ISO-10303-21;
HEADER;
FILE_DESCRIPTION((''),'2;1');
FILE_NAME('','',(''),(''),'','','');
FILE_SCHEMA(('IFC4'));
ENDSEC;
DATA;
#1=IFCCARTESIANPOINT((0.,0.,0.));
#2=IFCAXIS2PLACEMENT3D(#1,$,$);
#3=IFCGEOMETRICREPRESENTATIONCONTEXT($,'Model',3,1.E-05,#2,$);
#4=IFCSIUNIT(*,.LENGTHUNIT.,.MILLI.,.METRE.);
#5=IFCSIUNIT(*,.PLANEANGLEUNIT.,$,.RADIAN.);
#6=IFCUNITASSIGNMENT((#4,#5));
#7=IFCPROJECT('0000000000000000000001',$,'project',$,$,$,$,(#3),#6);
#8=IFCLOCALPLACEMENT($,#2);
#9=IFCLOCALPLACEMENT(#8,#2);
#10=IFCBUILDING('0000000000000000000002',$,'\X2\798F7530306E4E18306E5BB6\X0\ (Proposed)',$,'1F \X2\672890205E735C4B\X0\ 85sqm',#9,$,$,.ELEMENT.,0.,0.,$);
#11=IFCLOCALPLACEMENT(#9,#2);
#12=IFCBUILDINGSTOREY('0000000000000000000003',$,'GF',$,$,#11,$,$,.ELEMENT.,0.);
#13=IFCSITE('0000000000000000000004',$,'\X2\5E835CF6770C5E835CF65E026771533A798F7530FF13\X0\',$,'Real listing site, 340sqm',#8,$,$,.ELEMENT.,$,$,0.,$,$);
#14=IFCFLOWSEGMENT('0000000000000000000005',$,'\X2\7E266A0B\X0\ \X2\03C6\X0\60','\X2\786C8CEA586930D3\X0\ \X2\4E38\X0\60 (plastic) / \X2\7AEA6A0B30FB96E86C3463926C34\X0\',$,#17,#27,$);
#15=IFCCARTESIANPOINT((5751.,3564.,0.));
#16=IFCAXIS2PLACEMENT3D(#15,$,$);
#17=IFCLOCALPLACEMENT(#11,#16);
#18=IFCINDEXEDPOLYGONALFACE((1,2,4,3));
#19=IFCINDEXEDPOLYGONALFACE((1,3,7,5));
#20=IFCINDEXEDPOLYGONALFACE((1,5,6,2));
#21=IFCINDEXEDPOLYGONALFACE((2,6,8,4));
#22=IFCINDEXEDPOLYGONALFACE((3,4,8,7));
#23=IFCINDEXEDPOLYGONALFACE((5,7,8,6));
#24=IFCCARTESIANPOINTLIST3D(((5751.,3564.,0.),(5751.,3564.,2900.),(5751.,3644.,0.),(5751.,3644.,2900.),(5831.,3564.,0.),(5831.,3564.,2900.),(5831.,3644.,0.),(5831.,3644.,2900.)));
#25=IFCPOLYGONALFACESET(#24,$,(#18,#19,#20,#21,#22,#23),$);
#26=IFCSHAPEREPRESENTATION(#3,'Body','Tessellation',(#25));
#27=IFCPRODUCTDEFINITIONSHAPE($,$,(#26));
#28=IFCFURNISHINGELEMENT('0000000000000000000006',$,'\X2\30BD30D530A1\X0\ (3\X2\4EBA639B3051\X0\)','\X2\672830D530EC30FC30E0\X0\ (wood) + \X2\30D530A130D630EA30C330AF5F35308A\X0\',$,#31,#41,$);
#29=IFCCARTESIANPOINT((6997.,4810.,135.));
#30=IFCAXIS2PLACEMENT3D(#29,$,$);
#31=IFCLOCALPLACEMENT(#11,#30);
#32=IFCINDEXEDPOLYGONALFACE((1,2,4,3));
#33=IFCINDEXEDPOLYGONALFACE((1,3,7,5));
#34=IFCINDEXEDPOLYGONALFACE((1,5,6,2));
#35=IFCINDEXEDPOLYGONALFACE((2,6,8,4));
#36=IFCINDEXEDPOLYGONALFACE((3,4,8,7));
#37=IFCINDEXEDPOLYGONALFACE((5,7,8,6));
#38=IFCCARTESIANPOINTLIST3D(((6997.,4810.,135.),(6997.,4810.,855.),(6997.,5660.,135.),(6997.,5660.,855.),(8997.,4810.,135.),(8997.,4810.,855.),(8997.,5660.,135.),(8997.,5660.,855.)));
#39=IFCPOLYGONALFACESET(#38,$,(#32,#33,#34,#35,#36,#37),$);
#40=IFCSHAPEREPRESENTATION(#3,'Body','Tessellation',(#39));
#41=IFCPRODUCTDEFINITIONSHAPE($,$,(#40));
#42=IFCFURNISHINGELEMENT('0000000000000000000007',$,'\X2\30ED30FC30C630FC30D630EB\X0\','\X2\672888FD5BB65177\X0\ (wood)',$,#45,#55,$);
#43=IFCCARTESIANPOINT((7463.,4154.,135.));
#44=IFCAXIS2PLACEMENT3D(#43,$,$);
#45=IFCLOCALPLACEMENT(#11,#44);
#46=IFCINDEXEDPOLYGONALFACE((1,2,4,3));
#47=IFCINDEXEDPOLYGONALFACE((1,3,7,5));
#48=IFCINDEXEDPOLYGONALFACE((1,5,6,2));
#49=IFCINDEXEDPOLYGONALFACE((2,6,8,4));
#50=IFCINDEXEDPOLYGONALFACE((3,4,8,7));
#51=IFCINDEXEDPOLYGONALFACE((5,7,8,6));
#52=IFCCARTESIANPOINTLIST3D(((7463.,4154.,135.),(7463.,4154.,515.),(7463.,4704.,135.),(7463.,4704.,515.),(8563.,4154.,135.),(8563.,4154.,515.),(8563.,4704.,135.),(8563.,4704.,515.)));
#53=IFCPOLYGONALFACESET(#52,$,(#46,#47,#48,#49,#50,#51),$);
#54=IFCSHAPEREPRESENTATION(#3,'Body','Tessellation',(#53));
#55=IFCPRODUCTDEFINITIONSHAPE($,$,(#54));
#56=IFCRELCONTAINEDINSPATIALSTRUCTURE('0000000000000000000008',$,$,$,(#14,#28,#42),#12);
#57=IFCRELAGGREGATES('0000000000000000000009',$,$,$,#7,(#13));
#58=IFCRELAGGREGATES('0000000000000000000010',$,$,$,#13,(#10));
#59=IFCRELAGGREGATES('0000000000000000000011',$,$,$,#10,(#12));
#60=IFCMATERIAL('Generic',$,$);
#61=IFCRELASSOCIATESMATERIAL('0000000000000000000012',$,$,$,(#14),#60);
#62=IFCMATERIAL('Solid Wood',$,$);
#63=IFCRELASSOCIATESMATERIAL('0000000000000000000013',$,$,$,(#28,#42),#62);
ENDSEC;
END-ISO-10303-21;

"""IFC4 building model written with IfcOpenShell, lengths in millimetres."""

from ifc_helpers import new_model, si_unit, frame, frame_2d, origin, place, context, project, spatial, rectangle, extrude, material, element, save


model = new_model("IFC4")

# Units and contexts
model_context = context("Model", 3, precision=1e-05, world=origin())
ifc_project = project(units=[si_unit("LENGTHUNIT", "METRE", prefix="MILLI"), si_unit("PLANEANGLEUNIT", "RADIAN")], contexts=[model_context])

# Site, building, storey
site_placement = place(None, origin())
site = spatial("IfcSite", under=ifc_project, at=site_placement, Name="広島県広島市東区福田３", ObjectType="Real listing site, 340sqm", CompositionType="ELEMENT", RefElevation=0.0)
building_placement = place(site_placement, origin())
building = spatial("IfcBuilding", under=site, at=building_placement, Name="福田の丘の家 (Proposed)", ObjectType="1F 木造平屋 85sqm", CompositionType="ELEMENT", ElevationOfRefHeight=0.0, ElevationOfTerrain=0.0)
storey_placement = place(building_placement, origin())
storey = spatial("IfcBuildingStorey", under=building, at=storey_placement, Name="GF", CompositionType="ELEMENT", Elevation=0.0)

# Shared definitions
ifc_material_1 = material(Name="Solid Wood")

# Shared definitions
ifc_material_2 = material(Name="Generic")

# Flow segment
flow_segment_1_placement = place(storey_placement, frame((5751.0, 3564.0, 0.0)))
element("IfcFlowSegment", 1, at=flow_segment_1_placement, inside=storey, material=ifc_material_2, Name="縦樋 φ60", Description="硬質塩ビ 丸60 (plastic) / 竪樋・雨水排水", context=model_context, shape_type="SweptSolid", body=[
    extrude(rectangle(XDim=80.0, YDim=80.0, at=frame_2d((40.0, 40.0))), frame((5751.0, 3564.0, 0.0)), (0.0, 0.0, 1.0), 2900.0),
])

# Furnishing elements
furnishing_1_placement = place(storey_placement, frame((6997.0, 4810.0, 135.0)))
element("IfcFurnishingElement", 2, at=furnishing_1_placement, inside=storey, material=ifc_material_1, Name="ソファ (3人掛け)", Description="木フレーム (wood) + ファブリック張り", context=model_context, shape_type="SweptSolid", body=[
    extrude(rectangle(XDim=2000.0, YDim=850.0, at=frame_2d((1000.0, 425.0))), frame((6997.0, 4810.0, 135.0)), (0.0, 0.0, 1.0), 720.0),
])
furnishing_2_placement = place(storey_placement, frame((7463.0, 4154.0, 135.0)))
element("IfcFurnishingElement", 3, at=furnishing_2_placement, inside=storey, material=ifc_material_1, Name="ローテーブル", Description="木製家具 (wood)", context=model_context, shape_type="SweptSolid", body=[
    extrude(rectangle(XDim=1100.0, YDim=550.0, at=frame_2d((550.0, 275.0))), frame((7463.0, 4154.0, 135.0)), (0.0, 0.0, 1.0), 380.0),
])

save(model, "model.ifc")
